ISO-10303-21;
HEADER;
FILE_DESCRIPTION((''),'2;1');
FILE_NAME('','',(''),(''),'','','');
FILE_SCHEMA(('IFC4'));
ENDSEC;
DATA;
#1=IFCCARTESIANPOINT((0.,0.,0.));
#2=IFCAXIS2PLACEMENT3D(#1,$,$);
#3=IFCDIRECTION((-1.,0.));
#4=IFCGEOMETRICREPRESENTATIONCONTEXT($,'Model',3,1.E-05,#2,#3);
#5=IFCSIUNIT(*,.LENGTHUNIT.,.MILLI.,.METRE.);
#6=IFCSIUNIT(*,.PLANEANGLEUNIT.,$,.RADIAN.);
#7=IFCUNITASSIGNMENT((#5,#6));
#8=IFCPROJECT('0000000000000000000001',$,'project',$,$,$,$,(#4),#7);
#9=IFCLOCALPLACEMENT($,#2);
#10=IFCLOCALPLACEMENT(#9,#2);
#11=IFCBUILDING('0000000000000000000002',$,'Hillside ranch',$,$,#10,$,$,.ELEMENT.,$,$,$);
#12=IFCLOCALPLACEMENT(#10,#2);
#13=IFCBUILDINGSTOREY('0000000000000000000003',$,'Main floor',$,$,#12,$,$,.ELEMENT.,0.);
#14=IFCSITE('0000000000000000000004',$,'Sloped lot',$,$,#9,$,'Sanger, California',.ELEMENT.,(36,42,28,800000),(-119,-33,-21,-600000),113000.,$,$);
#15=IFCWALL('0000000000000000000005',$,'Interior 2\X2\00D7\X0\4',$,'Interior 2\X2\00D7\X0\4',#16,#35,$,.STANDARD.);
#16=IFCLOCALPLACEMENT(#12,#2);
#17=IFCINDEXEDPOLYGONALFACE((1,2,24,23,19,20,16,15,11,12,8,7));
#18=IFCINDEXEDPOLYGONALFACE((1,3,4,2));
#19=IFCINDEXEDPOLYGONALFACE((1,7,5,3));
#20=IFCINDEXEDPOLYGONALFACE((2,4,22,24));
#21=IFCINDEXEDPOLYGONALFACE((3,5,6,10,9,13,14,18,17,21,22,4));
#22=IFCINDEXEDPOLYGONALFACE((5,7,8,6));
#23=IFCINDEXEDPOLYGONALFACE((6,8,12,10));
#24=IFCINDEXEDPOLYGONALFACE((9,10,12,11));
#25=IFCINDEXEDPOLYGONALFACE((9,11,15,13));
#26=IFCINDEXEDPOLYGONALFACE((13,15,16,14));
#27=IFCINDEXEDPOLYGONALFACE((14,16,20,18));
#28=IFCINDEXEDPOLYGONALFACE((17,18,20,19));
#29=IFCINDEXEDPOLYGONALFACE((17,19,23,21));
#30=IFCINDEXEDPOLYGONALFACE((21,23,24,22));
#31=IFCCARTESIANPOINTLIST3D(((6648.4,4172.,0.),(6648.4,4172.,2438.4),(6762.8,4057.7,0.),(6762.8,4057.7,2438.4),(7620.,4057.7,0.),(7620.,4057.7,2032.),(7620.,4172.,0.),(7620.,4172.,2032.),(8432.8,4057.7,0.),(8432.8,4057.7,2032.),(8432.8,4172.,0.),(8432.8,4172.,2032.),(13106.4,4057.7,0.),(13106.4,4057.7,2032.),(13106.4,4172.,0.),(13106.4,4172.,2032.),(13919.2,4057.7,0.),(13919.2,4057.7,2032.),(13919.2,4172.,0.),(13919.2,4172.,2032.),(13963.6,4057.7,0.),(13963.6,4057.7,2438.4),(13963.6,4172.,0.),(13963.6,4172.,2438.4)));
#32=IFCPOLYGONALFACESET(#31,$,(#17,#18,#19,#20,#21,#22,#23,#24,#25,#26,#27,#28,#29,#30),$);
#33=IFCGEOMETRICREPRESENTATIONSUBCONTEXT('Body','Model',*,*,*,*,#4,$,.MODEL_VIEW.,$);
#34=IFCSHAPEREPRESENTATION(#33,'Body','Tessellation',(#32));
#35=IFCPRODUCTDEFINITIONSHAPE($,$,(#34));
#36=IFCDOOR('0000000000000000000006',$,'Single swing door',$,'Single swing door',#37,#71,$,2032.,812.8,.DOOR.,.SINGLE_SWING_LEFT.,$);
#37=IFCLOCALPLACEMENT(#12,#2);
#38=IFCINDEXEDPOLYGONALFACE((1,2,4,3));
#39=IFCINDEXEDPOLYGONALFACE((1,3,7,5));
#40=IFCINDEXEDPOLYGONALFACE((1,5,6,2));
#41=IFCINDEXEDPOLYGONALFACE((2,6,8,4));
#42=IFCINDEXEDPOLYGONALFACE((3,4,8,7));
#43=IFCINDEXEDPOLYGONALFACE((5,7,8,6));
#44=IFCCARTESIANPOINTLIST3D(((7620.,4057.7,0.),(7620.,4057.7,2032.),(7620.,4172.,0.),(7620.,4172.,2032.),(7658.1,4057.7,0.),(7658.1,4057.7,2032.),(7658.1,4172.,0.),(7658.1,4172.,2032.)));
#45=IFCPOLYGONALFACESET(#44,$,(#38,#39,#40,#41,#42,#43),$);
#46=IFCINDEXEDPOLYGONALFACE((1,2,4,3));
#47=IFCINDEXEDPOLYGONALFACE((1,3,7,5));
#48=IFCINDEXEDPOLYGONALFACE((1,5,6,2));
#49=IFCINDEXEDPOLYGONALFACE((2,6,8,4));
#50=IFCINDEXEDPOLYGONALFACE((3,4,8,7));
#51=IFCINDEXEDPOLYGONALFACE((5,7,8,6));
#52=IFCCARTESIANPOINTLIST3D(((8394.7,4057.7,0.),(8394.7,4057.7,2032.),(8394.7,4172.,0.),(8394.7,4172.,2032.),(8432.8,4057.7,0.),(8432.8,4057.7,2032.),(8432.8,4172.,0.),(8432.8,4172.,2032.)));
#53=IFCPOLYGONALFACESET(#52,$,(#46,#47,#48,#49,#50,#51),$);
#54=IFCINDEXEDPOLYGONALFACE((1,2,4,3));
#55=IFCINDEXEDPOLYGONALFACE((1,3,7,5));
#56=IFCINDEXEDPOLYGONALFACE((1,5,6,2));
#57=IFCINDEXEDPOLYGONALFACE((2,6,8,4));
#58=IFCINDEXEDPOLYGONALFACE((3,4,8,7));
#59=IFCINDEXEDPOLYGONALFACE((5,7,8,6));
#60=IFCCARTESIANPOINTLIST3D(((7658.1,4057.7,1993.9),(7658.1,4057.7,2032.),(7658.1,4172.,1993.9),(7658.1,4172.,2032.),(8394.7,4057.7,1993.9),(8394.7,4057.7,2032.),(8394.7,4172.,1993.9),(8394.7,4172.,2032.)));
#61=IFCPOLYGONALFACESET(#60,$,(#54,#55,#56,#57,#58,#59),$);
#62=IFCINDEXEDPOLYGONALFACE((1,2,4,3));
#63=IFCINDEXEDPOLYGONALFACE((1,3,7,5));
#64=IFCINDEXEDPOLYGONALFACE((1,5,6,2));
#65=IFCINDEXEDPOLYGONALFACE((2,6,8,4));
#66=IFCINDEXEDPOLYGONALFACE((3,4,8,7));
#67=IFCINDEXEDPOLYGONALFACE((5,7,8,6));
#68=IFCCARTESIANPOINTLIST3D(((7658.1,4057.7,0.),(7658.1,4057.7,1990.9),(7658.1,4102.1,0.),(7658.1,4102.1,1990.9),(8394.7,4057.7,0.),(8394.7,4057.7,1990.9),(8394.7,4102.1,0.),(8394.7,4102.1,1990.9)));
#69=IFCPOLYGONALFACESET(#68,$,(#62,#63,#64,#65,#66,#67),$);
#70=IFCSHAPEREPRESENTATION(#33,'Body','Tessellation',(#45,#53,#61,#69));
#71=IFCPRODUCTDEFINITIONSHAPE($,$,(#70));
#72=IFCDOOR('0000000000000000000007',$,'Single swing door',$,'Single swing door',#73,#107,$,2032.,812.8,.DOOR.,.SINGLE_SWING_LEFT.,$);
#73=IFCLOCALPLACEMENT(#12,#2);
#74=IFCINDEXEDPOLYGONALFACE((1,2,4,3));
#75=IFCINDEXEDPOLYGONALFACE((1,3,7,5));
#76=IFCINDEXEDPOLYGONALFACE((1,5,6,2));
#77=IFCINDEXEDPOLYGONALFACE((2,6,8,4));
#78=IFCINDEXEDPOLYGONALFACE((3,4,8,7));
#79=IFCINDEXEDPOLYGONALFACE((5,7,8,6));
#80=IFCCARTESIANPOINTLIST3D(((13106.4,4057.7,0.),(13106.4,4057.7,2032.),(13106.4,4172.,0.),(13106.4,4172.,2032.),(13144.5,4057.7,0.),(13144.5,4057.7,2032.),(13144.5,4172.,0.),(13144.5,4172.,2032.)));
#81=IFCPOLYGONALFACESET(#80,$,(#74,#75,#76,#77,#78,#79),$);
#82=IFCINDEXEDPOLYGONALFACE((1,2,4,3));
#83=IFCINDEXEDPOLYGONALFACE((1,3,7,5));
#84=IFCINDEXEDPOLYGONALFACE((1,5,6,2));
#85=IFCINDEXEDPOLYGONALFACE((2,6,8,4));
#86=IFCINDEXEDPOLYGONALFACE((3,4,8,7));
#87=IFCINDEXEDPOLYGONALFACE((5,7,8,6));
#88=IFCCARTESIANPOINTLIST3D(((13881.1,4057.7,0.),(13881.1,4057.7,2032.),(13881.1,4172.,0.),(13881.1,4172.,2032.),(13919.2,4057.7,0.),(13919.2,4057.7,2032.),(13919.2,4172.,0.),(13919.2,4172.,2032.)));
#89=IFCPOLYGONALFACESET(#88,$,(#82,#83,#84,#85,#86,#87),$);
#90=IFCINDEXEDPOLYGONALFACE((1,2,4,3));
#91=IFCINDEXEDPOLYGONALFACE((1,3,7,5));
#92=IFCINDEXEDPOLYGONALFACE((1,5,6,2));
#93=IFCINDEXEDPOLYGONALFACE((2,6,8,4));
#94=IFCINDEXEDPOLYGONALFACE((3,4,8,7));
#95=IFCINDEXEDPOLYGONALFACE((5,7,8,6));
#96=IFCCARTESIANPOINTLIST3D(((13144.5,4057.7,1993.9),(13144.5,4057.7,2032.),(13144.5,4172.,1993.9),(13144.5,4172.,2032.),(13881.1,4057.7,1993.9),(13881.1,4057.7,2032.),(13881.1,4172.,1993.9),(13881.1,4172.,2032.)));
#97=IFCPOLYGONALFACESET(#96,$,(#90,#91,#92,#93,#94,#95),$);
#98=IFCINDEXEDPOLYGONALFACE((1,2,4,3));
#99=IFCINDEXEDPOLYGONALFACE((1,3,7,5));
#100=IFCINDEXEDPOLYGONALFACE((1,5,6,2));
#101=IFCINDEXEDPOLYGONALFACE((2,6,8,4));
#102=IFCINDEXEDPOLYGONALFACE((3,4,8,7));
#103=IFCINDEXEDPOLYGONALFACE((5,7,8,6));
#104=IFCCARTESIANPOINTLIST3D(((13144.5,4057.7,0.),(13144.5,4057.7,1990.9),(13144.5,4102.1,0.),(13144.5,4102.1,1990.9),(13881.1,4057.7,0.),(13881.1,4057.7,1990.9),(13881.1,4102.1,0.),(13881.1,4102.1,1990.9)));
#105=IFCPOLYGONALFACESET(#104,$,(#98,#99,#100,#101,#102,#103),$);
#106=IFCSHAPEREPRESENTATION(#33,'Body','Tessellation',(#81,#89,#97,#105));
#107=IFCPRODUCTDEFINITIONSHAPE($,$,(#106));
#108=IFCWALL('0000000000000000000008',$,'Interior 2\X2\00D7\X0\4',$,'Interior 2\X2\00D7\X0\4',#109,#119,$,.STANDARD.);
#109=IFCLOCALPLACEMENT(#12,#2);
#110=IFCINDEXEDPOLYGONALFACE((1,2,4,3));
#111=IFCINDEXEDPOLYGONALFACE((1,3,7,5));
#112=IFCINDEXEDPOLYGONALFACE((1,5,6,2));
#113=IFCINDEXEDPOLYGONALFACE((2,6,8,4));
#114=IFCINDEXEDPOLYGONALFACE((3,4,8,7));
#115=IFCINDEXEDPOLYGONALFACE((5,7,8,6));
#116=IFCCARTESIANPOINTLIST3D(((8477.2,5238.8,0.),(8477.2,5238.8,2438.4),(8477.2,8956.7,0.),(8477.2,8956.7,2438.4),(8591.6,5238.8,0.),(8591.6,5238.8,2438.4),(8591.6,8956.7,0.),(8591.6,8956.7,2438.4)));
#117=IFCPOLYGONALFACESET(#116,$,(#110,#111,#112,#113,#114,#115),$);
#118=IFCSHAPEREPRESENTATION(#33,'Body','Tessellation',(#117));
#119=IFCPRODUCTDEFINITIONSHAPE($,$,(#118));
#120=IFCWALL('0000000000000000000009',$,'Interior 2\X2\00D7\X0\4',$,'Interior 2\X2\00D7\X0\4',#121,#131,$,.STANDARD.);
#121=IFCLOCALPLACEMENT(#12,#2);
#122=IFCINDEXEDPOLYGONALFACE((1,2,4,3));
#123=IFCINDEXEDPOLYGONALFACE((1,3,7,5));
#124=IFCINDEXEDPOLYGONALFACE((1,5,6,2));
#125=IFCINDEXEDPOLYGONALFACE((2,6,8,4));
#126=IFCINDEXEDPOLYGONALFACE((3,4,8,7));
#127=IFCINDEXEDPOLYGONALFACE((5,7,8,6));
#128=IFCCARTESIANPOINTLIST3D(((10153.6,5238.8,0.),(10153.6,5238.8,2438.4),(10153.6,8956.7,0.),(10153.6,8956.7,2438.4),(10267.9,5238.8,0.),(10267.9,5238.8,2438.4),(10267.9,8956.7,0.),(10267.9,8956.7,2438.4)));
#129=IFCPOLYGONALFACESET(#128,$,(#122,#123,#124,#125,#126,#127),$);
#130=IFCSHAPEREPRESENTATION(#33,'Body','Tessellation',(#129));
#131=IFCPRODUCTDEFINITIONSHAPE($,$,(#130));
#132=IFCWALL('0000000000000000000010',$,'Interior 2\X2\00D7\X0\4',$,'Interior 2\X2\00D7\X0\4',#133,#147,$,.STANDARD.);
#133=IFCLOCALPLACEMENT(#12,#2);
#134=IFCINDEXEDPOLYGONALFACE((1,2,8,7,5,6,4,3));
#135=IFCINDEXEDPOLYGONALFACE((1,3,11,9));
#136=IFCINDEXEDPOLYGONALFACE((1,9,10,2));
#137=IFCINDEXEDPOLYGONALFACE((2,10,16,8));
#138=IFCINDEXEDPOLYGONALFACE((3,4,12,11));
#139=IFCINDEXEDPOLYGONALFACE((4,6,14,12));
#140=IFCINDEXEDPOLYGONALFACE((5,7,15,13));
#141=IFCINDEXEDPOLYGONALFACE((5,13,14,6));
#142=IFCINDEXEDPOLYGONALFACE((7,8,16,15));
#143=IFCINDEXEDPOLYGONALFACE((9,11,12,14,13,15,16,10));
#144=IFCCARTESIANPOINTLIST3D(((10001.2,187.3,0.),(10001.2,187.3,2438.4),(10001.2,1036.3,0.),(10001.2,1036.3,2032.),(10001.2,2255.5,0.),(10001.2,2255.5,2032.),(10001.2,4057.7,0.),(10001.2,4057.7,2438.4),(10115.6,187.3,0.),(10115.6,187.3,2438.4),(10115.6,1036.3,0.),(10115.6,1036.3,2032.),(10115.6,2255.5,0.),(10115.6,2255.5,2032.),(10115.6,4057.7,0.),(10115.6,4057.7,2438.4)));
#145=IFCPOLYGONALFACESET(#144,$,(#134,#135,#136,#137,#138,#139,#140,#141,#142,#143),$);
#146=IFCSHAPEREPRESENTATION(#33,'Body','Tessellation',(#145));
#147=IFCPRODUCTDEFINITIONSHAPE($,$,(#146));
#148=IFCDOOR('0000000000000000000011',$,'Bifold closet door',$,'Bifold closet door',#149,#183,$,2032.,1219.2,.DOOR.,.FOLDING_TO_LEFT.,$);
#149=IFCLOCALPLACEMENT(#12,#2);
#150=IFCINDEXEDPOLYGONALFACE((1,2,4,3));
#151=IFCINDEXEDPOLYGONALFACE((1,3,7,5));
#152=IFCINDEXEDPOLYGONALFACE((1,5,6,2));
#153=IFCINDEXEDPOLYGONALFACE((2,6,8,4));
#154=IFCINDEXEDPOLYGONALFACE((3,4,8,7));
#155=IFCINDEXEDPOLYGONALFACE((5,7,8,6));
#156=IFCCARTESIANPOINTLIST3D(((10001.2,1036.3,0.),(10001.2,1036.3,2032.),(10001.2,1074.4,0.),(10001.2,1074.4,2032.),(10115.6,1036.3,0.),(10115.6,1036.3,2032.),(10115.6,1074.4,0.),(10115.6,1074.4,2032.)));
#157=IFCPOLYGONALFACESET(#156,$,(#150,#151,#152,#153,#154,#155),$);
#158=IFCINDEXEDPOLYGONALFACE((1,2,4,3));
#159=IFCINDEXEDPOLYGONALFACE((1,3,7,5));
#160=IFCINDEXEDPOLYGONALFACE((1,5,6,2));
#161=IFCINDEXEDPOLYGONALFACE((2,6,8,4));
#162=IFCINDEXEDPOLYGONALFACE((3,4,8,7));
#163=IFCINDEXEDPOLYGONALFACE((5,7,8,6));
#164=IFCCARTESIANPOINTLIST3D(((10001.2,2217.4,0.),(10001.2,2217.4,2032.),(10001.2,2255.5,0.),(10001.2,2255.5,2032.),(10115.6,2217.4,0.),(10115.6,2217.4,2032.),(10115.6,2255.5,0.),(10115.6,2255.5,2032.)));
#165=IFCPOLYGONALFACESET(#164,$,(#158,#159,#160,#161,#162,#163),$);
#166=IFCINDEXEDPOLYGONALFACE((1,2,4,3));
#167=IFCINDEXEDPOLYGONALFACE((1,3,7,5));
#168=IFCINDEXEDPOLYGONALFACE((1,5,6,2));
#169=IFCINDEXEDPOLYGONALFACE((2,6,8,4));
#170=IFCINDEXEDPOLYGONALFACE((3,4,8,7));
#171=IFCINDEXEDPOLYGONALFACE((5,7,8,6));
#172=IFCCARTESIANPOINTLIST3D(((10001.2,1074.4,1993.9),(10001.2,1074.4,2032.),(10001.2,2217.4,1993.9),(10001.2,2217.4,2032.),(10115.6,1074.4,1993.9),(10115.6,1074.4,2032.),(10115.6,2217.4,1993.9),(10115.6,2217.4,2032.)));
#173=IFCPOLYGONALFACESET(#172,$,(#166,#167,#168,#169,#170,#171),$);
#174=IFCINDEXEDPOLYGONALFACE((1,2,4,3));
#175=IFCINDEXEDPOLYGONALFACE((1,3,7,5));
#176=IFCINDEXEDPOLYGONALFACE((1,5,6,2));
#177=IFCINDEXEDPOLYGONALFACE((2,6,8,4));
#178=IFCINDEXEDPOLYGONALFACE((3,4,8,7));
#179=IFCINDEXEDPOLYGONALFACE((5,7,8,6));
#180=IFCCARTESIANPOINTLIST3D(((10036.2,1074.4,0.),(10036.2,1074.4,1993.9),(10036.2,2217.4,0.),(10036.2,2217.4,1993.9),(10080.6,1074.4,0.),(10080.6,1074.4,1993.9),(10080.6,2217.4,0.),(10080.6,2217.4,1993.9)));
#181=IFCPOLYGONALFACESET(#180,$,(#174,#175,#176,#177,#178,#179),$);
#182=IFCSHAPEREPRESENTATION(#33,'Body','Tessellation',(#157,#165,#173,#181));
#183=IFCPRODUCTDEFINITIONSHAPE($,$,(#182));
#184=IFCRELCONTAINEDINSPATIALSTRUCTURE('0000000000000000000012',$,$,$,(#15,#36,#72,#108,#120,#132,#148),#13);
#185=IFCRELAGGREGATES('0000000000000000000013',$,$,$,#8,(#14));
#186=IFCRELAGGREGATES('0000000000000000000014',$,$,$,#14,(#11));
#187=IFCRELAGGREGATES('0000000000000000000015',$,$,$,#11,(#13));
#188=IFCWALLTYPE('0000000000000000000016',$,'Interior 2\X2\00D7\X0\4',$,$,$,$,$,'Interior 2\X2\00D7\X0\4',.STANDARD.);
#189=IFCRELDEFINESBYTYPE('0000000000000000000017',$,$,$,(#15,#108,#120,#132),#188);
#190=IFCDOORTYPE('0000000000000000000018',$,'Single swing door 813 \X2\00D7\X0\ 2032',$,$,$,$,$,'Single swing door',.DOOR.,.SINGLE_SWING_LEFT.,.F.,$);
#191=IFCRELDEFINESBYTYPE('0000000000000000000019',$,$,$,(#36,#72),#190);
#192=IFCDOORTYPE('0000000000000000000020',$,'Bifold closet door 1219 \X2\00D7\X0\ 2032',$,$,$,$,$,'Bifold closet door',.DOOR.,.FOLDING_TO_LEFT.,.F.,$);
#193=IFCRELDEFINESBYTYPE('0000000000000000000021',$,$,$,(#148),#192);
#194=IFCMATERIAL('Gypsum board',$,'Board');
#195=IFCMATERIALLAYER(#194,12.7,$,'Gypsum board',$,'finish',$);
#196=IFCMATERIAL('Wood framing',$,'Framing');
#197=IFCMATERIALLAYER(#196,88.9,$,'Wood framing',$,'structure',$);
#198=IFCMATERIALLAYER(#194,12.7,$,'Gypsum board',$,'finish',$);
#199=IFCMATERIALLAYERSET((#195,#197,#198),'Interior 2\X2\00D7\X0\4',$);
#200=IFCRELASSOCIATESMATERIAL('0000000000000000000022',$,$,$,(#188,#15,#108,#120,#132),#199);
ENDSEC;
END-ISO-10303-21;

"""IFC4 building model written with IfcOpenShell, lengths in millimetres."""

from ifc_helpers import new_model, si_unit, direction, frame, origin, origin_with_axes, place, context, subcontext, project, spatial, polyline, outline, extrude, material, layer, layer_set, layer_usage, type_object, element, fill, save


model = new_model("IFC4")

# Units and contexts
model_context = context("Model", 3, precision=1e-05, world=origin(), true_north=direction((-1.0, 0.0)))
body_context = subcontext(model_context, "Body", "Model", "MODEL_VIEW")
ifc_project = project(units=[si_unit("LENGTHUNIT", "METRE", prefix="MILLI"), si_unit("PLANEANGLEUNIT", "RADIAN")], contexts=[model_context])

# Site, building, storey
site_placement = place(None, origin())
site = spatial("IfcSite", under=ifc_project, at=site_placement, Name="Sloped lot", LongName="Sanger, California", CompositionType="ELEMENT", RefLatitude=(36, 42, 28, 800000), RefLongitude=(-119, -33, -21, -600000), RefElevation=113000.0)
building_placement = place(site_placement, origin())
building = spatial("IfcBuilding", under=site, at=building_placement, Name="Hillside ranch", CompositionType="ELEMENT")
storey_placement = place(building_placement, origin())
storey = spatial("IfcBuildingStorey", under=building, at=storey_placement, Name="Main floor", CompositionType="ELEMENT", Elevation=0.0)

# Wall, openings, doors
ifc_material_1 = material(Name="Gypsum board", Category="Board")
ifc_layer_1 = layer(ifc_material_1, 12.7, Name="Gypsum board", Category="finish")
ifc_material_2 = material(Name="Wood framing", Category="Framing")
ifc_layer_2 = layer(ifc_material_2, 88.9, Name="Wood framing", Category="structure")
ifc_layer_3 = layer(ifc_material_1, 12.7, Name="Gypsum board", Category="finish")
ifc_layer_set = layer_set([ifc_layer_1, ifc_layer_2, ifc_layer_3], Name="Interior 2×4")
wall_type = type_object("IfcWallType", Name="Interior 2×4", ElementType="Interior 2×4", PredefinedType="STANDARD", material=ifc_layer_set)
door_type_1 = type_object("IfcDoorType", Name="Single swing door 813 × 2032", ElementType="Single swing door", OperationType="SINGLE_SWING_LEFT", ParameterTakesPrecedence=False, PredefinedType="DOOR")
ifc_layer_usage_1 = layer_usage(ifc_layer_set, "AXIS2", "NEGATIVE", 57.1)
wall_1_placement = place(storey_placement, frame((6705.6, 4114.8, 0.0), z_axis=(0.0, 0.0, 1.0), x_axis=(1.0, 0.0, 0.0)))
wall_1 = element("IfcWall", 1, at=wall_1_placement, inside=storey, type_object=wall_type, material=ifc_layer_usage_1, Name="Interior 2×4", ObjectType="Interior 2×4", PredefinedType="STANDARD", context=body_context, shape_type="SweptSolid", body=[
    extrude(outline(polyline([(57.1, -57.1), (7258.1, -57.1), (7258.1, 57.1), (-57.1, 57.1), (57.1, -57.1)])), origin(), (0.0, 0.0, 1.0), 2438.4),
])
opening_1_placement = place(wall_1_placement, frame((914.4, 0.0, 0.0), z_axis=(0.0, 0.0, 1.0), x_axis=(1.0, 0.0, 0.0)))
opening_1 = element("IfcOpeningElement", 2, at=opening_1_placement, cuts=wall_1, PredefinedType="OPENING", context=body_context, shape_type="SweptSolid", body=[
    extrude(outline(polyline([(0.0, -67.2), (812.8, -67.2), (812.8, 67.2), (0.0, 67.2), (0.0, -67.2)])), origin(), (0.0, 0.0, 1.0), 2032.0),
])
opening_2_placement = place(wall_1_placement, frame((6400.8, 0.0, 0.0), z_axis=(0.0, 0.0, 1.0), x_axis=(1.0, 0.0, 0.0)))
opening_2 = element("IfcOpeningElement", 3, at=opening_2_placement, cuts=wall_1, PredefinedType="OPENING", context=body_context, shape_type="SweptSolid", body=[
    extrude(outline(polyline([(0.0, -67.2), (812.8, -67.2), (812.8, 67.2), (0.0, 67.2), (0.0, -67.2)])), origin(), (0.0, 0.0, 1.0), 2032.0),
])
door_1_placement = place(opening_1_placement, origin_with_axes())
door_1 = element("IfcDoor", 4, at=door_1_placement, inside=storey, type_object=door_type_1, Name="Single swing door", ObjectType="Single swing door", OperationType="SINGLE_SWING_LEFT", OverallHeight=2032.0, OverallWidth=812.8, PredefinedType="DOOR", context=body_context, shape_type="SweptSolid", body=[
    extrude(outline(polyline([(0.0, -57.1), (38.1, -57.1), (38.1, 57.1), (0.0, 57.1), (0.0, -57.1)])), origin(), (0.0, 0.0, 1.0), 2032.0),
    extrude(outline(polyline([(774.7, -57.1), (812.8, -57.1), (812.8, 57.1), (774.7, 57.1), (774.7, -57.1)])), origin(), (0.0, 0.0, 1.0), 2032.0),
    extrude(outline(polyline([(38.1, -57.1), (774.7, -57.1), (774.7, 57.1), (38.1, 57.1), (38.1, -57.1)])), frame((0.0, 0.0, 1993.9)), (0.0, 0.0, 1.0), 38.1),
    extrude(outline(polyline([(38.1, -57.1), (774.7, -57.1), (774.7, -12.7), (38.1, -12.7), (38.1, -57.1)])), origin(), (0.0, 0.0, 1.0), 1990.9),
])
fill(opening_1, door_1)
door_2_placement = place(opening_2_placement, origin_with_axes())
door_2 = element("IfcDoor", 5, at=door_2_placement, inside=storey, type_object=door_type_1, Name="Single swing door", ObjectType="Single swing door", OperationType="SINGLE_SWING_LEFT", OverallHeight=2032.0, OverallWidth=812.8, PredefinedType="DOOR", context=body_context, shape_type="SweptSolid", body=[
    extrude(outline(polyline([(0.0, -57.1), (38.1, -57.1), (38.1, 57.1), (0.0, 57.1), (0.0, -57.1)])), origin(), (0.0, 0.0, 1.0), 2032.0),
    extrude(outline(polyline([(774.7, -57.1), (812.8, -57.1), (812.8, 57.1), (774.7, 57.1), (774.7, -57.1)])), origin(), (0.0, 0.0, 1.0), 2032.0),
    extrude(outline(polyline([(38.1, -57.1), (774.7, -57.1), (774.7, 57.1), (38.1, 57.1), (38.1, -57.1)])), frame((0.0, 0.0, 1993.9)), (0.0, 0.0, 1.0), 38.1),
    extrude(outline(polyline([(38.1, -57.1), (774.7, -57.1), (774.7, -12.7), (38.1, -12.7), (38.1, -57.1)])), origin(), (0.0, 0.0, 1.0), 1990.9),
])
fill(opening_2, door_2)

# Walls
ifc_layer_usage_2 = layer_usage(ifc_layer_set, "AXIS2", "NEGATIVE", 57.1)
wall_2_placement = place(storey_placement, frame((8534.4, 5181.6, 0.0), z_axis=(0.0, 0.0, 1.0), x_axis=(0.0, 1.0, 0.0)))
element("IfcWall", 6, at=wall_2_placement, inside=storey, type_object=wall_type, material=ifc_layer_usage_2, Name="Interior 2×4", ObjectType="Interior 2×4", PredefinedType="STANDARD", context=body_context, shape_type="SweptSolid", body=[
    extrude(outline(polyline([(57.1, -57.1), (3775.1, -57.1), (3775.1, 57.1), (57.1, 57.1), (57.1, -57.1)])), origin(), (0.0, 0.0, 1.0), 2438.4),
])
ifc_layer_usage_3 = layer_usage(ifc_layer_set, "AXIS2", "NEGATIVE", 57.1)
wall_3_placement = place(storey_placement, frame((10210.8, 5181.6, 0.0), z_axis=(0.0, 0.0, 1.0), x_axis=(0.0, 1.0, 0.0)))
element("IfcWall", 7, at=wall_3_placement, inside=storey, type_object=wall_type, material=ifc_layer_usage_3, Name="Interior 2×4", ObjectType="Interior 2×4", PredefinedType="STANDARD", context=body_context, shape_type="SweptSolid", body=[
    extrude(outline(polyline([(57.1, -57.1), (3775.1, -57.1), (3775.1, 57.1), (57.1, 57.1), (57.1, -57.1)])), origin(), (0.0, 0.0, 1.0), 2438.4),
])

# Wall, opening, door
ifc_layer_usage_4 = layer_usage(ifc_layer_set, "AXIS2", "NEGATIVE", 57.1)
wall_4_placement = place(storey_placement, frame((10058.4, 93.7, 0.0), z_axis=(0.0, 0.0, 1.0), x_axis=(0.0, 1.0, 0.0)))
wall_4 = element("IfcWall", 8, at=wall_4_placement, inside=storey, type_object=wall_type, material=ifc_layer_usage_4, Name="Interior 2×4", ObjectType="Interior 2×4", PredefinedType="STANDARD", context=body_context, shape_type="SweptSolid", body=[
    extrude(outline(polyline([(93.7, -57.1), (3964.0, -57.1), (3964.0, 57.1), (93.7, 57.1), (93.7, -57.1)])), origin(), (0.0, 0.0, 1.0), 2438.4),
])
opening_3_placement = place(wall_4_placement, frame((942.7, 0.0, 0.0), z_axis=(0.0, 0.0, 1.0), x_axis=(1.0, 0.0, 0.0)))
opening_3 = element("IfcOpeningElement", 9, at=opening_3_placement, cuts=wall_4, PredefinedType="OPENING", context=body_context, shape_type="SweptSolid", body=[
    extrude(outline(polyline([(0.0, -67.2), (1219.2, -67.2), (1219.2, 67.2), (0.0, 67.2), (0.0, -67.2)])), origin(), (0.0, 0.0, 1.0), 2032.0),
])
door_type_2 = type_object("IfcDoorType", Name="Bifold closet door 1219 × 2032", ElementType="Bifold closet door", OperationType="FOLDING_TO_LEFT", ParameterTakesPrecedence=False, PredefinedType="DOOR")
door_3_placement = place(opening_3_placement, origin_with_axes())
door_3 = element("IfcDoor", 10, at=door_3_placement, inside=storey, type_object=door_type_2, Name="Bifold closet door", ObjectType="Bifold closet door", OperationType="FOLDING_TO_LEFT", OverallHeight=2032.0, OverallWidth=1219.2, PredefinedType="DOOR", context=body_context, shape_type="SweptSolid", body=[
    extrude(outline(polyline([(0.0, -57.1), (38.1, -57.1), (38.1, 57.1), (0.0, 57.1), (0.0, -57.1)])), origin(), (0.0, 0.0, 1.0), 2032.0),
    extrude(outline(polyline([(1181.1, -57.1), (1219.2, -57.1), (1219.2, 57.1), (1181.1, 57.1), (1181.1, -57.1)])), origin(), (0.0, 0.0, 1.0), 2032.0),
    extrude(outline(polyline([(38.1, -57.1), (1181.1, -57.1), (1181.1, 57.1), (38.1, 57.1), (38.1, -57.1)])), frame((0.0, 0.0, 1993.9)), (0.0, 0.0, 1.0), 38.1),
    extrude(outline(polyline([(38.1, -22.2), (1181.1, -22.2), (1181.1, 22.2), (38.1, 22.2), (38.1, -22.2)])), origin(), (0.0, 0.0, 1.0), 1993.9),
])
fill(opening_3, door_3)

save(model, "model.ifc")
